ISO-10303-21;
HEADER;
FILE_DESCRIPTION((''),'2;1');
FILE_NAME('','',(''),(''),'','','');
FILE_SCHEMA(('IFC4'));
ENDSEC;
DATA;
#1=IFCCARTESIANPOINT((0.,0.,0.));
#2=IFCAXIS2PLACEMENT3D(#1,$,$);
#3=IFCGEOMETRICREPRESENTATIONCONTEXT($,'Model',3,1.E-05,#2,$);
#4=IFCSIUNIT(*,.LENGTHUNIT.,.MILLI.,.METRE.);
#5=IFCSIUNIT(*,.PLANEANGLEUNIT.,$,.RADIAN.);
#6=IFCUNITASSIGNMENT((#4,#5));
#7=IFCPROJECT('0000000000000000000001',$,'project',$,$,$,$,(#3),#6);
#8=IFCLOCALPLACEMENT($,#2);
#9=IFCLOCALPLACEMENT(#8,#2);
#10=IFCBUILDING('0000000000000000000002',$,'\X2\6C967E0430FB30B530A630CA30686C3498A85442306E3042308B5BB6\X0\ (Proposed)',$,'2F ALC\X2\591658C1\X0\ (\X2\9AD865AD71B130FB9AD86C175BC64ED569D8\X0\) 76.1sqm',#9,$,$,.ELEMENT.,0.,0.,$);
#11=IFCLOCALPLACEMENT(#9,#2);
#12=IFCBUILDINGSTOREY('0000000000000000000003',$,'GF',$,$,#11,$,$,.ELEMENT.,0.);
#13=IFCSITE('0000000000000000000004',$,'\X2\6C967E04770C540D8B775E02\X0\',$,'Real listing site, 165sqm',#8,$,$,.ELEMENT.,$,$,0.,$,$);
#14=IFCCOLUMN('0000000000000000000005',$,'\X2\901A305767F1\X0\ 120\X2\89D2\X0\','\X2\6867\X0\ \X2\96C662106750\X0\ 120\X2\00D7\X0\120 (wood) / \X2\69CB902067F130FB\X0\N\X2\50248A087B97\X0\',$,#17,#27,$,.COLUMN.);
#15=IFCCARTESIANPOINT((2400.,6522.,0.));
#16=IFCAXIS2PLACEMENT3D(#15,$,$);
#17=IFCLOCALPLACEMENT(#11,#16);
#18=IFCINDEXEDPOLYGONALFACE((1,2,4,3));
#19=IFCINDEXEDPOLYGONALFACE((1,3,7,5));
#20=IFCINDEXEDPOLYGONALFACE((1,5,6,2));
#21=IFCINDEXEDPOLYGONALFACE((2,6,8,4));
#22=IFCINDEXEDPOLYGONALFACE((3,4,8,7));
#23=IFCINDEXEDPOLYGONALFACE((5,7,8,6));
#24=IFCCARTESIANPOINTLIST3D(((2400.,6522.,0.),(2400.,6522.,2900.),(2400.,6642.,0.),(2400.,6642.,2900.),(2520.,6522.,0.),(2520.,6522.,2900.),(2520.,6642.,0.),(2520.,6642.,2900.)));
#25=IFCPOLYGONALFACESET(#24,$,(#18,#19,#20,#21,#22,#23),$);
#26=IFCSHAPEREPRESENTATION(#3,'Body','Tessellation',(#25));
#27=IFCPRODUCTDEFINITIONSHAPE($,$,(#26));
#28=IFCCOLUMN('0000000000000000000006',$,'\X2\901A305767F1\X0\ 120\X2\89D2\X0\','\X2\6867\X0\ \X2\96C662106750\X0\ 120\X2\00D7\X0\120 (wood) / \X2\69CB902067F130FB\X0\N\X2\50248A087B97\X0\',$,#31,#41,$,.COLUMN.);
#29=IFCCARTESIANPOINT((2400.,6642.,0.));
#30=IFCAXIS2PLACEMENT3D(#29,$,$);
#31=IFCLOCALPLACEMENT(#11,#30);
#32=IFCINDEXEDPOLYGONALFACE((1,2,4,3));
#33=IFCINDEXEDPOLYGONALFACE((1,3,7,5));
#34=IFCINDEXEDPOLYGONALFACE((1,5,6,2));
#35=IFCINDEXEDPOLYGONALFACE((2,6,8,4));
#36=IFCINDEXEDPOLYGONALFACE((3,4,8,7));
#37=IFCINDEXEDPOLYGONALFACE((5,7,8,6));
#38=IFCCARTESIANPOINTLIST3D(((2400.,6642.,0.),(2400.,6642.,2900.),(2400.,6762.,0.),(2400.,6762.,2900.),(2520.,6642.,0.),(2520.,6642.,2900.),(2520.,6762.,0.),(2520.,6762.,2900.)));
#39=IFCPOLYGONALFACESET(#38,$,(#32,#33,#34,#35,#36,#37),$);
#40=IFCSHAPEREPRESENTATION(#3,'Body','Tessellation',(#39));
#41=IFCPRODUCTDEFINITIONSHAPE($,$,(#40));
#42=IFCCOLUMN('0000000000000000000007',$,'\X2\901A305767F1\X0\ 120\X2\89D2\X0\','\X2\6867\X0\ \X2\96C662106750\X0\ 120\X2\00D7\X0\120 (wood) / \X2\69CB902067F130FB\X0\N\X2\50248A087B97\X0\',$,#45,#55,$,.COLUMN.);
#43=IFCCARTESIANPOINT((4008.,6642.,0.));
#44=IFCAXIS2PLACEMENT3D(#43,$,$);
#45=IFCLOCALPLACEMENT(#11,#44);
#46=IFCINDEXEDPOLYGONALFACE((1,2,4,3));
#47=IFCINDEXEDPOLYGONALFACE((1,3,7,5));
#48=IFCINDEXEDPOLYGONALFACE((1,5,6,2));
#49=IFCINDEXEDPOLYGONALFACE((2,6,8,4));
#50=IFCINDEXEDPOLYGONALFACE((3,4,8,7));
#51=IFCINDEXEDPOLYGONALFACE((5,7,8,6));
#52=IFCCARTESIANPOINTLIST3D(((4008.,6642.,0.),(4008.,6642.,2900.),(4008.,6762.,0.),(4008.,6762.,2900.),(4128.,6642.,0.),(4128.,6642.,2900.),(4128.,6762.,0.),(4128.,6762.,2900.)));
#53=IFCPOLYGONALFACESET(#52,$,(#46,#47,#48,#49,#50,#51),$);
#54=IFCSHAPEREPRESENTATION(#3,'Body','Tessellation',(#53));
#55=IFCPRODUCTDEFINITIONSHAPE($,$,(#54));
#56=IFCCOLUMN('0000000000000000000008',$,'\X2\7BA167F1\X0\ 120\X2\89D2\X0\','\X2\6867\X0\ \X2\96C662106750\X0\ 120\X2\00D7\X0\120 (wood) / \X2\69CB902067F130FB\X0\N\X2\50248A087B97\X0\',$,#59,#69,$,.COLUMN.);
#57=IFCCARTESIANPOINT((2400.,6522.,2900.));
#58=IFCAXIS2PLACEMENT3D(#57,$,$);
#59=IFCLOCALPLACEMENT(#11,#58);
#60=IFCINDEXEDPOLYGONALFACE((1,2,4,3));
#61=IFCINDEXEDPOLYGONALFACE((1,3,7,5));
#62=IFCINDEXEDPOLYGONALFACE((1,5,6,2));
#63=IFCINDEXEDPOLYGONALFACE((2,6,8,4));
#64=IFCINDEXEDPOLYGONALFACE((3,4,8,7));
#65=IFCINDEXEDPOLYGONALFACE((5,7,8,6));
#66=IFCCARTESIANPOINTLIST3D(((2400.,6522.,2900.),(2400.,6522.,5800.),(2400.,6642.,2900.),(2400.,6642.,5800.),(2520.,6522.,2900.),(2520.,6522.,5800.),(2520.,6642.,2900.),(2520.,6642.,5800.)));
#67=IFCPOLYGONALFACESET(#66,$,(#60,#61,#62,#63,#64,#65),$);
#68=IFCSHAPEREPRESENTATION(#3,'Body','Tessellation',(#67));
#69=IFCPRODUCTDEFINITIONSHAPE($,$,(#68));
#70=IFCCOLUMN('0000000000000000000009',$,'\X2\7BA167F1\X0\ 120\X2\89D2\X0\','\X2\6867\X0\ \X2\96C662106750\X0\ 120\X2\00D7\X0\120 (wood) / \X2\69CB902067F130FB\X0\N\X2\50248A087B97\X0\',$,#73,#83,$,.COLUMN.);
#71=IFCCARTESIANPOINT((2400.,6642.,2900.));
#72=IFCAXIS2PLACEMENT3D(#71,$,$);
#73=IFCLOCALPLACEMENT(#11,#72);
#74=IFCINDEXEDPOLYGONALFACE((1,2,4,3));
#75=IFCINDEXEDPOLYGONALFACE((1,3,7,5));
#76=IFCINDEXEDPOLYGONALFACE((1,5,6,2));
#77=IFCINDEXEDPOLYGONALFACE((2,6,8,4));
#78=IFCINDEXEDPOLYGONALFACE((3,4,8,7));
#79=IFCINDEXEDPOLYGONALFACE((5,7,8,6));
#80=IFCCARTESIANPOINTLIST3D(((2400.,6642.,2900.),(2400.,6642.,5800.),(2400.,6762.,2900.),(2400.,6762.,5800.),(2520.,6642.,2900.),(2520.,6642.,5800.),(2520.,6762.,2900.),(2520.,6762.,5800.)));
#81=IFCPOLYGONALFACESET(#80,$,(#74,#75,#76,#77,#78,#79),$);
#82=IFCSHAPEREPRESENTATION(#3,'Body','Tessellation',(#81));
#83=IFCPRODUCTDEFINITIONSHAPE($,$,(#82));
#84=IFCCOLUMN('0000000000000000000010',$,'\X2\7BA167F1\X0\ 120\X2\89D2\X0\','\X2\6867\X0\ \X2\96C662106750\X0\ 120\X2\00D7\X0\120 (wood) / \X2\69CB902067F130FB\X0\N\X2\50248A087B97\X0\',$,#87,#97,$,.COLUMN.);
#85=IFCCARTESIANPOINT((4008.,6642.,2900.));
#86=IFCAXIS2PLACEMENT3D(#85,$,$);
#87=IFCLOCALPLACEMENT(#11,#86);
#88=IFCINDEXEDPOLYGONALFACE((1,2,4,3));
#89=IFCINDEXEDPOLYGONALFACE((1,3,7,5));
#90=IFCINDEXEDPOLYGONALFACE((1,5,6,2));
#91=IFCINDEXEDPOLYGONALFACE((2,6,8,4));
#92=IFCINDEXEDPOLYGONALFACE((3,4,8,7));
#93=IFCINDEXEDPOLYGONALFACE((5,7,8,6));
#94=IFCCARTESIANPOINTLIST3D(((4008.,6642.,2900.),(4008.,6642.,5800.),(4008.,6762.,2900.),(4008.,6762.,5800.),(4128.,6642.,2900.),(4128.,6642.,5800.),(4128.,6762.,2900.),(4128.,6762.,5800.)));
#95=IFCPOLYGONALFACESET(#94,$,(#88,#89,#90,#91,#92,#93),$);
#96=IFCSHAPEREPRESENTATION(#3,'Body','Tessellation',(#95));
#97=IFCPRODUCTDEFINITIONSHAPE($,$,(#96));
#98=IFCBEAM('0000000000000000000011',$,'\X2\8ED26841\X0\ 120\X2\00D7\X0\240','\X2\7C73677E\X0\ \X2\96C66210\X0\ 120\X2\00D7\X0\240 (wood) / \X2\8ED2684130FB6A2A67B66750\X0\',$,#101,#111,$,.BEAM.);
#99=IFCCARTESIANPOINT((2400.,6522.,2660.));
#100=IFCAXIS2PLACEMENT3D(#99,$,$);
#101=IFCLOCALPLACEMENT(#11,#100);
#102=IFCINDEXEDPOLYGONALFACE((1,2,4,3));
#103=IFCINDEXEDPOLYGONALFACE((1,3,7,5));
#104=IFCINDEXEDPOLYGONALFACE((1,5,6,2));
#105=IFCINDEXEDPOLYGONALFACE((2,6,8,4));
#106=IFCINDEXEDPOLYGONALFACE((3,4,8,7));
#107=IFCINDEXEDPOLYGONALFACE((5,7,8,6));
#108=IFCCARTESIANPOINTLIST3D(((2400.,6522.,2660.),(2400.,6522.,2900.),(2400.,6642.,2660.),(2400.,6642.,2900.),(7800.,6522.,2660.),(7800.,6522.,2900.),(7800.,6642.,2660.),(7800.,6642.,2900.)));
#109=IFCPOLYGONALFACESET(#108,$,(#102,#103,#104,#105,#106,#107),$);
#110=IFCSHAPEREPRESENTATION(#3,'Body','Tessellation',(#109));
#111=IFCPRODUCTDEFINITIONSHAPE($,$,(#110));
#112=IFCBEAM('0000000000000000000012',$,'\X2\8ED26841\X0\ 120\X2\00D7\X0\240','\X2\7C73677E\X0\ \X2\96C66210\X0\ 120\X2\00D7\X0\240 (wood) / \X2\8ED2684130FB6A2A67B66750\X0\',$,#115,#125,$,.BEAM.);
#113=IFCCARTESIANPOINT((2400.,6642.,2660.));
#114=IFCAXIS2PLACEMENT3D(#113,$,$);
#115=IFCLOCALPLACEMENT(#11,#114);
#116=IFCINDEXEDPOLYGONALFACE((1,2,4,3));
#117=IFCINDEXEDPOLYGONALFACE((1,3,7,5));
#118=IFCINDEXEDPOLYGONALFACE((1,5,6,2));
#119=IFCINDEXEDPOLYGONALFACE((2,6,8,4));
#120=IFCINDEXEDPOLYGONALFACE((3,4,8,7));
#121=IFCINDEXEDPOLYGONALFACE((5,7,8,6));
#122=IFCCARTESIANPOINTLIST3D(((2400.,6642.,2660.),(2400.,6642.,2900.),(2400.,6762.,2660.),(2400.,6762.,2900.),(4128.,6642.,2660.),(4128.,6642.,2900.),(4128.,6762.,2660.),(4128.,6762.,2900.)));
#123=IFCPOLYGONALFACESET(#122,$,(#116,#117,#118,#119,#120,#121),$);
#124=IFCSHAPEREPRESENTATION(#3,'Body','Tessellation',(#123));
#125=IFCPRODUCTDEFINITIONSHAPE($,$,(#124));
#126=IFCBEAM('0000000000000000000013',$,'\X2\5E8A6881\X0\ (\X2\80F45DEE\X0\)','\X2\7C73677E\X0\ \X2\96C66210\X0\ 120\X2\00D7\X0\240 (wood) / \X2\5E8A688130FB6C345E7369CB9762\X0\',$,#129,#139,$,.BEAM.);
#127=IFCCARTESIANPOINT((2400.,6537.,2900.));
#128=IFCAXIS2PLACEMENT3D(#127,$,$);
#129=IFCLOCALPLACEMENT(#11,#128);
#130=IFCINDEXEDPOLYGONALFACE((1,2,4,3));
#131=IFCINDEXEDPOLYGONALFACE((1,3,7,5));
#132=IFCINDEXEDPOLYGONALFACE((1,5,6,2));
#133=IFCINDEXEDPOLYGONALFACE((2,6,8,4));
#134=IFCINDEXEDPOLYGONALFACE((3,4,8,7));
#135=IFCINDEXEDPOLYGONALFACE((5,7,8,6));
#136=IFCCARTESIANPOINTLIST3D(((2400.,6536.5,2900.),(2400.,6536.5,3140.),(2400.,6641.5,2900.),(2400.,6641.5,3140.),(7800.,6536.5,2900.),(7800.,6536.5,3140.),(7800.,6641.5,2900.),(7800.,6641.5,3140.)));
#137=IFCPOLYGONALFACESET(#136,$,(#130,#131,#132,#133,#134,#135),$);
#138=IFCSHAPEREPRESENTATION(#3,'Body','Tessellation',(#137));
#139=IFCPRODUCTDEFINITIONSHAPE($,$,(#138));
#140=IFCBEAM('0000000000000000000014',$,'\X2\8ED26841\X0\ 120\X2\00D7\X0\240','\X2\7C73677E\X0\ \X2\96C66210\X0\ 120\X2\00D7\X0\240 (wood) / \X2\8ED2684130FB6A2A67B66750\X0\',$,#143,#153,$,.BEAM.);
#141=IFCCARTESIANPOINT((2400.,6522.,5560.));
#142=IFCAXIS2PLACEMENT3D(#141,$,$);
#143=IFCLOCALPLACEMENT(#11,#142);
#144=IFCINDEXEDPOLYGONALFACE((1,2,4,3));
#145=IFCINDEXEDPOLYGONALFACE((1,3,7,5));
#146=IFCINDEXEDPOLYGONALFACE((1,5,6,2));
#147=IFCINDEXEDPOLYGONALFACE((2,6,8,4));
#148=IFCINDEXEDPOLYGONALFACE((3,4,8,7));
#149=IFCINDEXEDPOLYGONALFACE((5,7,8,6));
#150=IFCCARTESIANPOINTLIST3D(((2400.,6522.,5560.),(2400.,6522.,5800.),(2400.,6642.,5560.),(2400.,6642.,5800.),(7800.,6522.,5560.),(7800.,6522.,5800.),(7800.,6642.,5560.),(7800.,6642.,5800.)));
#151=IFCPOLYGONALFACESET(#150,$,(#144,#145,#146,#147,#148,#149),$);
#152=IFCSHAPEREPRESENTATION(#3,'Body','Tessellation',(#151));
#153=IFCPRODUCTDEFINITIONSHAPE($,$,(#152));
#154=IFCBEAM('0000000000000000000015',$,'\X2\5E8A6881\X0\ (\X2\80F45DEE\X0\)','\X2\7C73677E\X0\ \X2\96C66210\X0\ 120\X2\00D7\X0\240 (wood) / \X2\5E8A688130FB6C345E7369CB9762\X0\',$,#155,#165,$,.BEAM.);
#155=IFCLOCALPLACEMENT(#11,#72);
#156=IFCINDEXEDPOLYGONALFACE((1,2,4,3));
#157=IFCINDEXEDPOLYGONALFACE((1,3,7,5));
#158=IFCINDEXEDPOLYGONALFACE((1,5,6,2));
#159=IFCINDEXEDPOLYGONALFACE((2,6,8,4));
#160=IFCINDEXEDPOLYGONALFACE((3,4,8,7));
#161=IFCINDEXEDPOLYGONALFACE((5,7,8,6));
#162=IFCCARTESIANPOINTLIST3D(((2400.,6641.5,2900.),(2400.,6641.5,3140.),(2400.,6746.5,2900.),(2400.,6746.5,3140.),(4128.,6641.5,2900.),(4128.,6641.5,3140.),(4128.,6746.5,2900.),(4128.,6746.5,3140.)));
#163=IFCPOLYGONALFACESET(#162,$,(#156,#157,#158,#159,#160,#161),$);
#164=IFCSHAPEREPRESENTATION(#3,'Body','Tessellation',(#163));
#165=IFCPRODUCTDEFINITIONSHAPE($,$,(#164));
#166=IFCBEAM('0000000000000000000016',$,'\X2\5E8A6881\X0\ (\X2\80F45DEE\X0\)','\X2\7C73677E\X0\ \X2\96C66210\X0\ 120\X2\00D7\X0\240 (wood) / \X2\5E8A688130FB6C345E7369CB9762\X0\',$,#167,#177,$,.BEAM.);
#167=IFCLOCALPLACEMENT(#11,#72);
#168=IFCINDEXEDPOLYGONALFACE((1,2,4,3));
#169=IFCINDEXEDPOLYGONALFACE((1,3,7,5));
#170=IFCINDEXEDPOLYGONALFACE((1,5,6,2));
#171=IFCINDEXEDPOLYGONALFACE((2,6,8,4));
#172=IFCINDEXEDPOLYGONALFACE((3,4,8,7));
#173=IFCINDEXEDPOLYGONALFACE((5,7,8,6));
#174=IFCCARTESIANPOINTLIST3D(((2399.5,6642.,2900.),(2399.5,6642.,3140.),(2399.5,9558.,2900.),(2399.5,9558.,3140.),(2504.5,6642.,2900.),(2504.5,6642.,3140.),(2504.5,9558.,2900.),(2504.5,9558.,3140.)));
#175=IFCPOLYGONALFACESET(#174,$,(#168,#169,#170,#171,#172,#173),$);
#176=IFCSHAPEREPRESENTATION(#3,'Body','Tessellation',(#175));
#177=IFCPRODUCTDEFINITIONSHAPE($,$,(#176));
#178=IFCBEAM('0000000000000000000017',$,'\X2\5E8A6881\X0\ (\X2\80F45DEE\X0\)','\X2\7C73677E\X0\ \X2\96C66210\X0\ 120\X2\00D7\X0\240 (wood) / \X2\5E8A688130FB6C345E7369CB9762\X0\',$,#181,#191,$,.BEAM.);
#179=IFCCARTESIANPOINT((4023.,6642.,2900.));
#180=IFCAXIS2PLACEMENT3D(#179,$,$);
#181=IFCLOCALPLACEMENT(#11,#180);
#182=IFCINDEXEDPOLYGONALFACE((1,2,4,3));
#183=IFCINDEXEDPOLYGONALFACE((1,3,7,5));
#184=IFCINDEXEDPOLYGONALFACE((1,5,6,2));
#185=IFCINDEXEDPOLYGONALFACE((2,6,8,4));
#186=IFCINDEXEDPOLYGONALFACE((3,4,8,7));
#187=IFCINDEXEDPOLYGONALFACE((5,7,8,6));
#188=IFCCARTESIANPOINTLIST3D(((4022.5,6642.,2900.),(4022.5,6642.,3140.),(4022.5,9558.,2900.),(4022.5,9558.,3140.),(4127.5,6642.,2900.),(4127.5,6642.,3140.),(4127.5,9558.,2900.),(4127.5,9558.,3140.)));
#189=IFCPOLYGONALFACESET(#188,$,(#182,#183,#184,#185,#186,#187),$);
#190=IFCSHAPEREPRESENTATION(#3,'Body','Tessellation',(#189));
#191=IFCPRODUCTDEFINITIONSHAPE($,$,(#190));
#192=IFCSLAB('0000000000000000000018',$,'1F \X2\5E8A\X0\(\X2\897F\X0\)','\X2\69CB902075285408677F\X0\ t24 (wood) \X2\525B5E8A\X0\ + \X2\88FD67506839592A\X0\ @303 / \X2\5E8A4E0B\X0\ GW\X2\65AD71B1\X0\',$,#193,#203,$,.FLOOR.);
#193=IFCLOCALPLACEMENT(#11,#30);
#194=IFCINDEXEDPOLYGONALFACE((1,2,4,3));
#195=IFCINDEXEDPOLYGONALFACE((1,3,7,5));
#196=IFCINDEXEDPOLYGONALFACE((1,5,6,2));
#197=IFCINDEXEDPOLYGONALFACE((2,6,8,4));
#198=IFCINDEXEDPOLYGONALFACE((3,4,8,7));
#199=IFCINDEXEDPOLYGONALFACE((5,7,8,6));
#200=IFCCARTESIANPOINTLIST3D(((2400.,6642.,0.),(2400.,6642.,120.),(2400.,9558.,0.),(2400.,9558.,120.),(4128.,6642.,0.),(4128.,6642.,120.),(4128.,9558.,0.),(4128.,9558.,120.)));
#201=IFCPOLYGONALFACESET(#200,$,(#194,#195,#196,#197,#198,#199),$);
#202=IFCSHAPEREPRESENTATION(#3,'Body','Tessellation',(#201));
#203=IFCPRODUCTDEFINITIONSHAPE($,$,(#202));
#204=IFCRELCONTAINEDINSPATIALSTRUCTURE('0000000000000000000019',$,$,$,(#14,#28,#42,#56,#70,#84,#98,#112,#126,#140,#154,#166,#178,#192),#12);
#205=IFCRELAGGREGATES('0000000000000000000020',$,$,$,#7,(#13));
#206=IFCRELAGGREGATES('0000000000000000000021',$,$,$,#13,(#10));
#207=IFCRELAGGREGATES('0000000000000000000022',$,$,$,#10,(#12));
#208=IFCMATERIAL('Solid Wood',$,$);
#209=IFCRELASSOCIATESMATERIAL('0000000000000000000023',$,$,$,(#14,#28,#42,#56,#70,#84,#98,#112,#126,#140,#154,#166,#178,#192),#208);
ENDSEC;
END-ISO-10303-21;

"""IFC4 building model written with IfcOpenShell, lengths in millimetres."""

from ifc_helpers import new_model, si_unit, frame, frame_2d, origin, place, context, project, spatial, rectangle, extrude, material, element, save


model = new_model("IFC4")

# Units and contexts
model_context = context("Model", 3, precision=1e-05, world=origin())
ifc_project = project(units=[si_unit("LENGTHUNIT", "METRE", prefix="MILLI"), si_unit("PLANEANGLEUNIT", "RADIAN")], contexts=[model_context])

# Site, building, storey
site_placement = place(None, origin())
site = spatial("IfcSite", under=ifc_project, at=site_placement, Name="沖縄県名護市", ObjectType="Real listing site, 165sqm", CompositionType="ELEMENT", RefElevation=0.0)
building_placement = place(site_placement, origin())
building = spatial("IfcBuilding", under=site, at=building_placement, Name="沖縄・サウナと水風呂のある家 (Proposed)", ObjectType="2F ALC外壁 (高断熱・高気密仕様) 76.1sqm", CompositionType="ELEMENT", ElevationOfRefHeight=0.0, ElevationOfTerrain=0.0)
storey_placement = place(building_placement, origin())
storey = spatial("IfcBuildingStorey", under=building, at=storey_placement, Name="GF", CompositionType="ELEMENT", Elevation=0.0)

# Columns
ifc_material_1 = material(Name="Solid Wood")
column_1_placement = place(storey_placement, frame((2400.0, 6522.0, 0.0)))
element("IfcColumn", 1, at=column_1_placement, inside=storey, material=ifc_material_1, Name="通し柱 120角", Description="桧 集成材 120×120 (wood) / 構造柱・N値計算", PredefinedType="COLUMN", context=model_context, shape_type="SweptSolid", body=[
    extrude(rectangle(XDim=120.0, YDim=120.0, at=frame_2d((60.0, 60.0))), frame((2400.0, 6522.0, 0.0)), (0.0, 0.0, 1.0), 2900.0),
])
column_2_placement = place(storey_placement, frame((2400.0, 6642.0, 0.0)))
element("IfcColumn", 2, at=column_2_placement, inside=storey, material=ifc_material_1, Name="通し柱 120角", Description="桧 集成材 120×120 (wood) / 構造柱・N値計算", PredefinedType="COLUMN", context=model_context, shape_type="SweptSolid", body=[
    extrude(rectangle(XDim=120.0, YDim=120.0, at=frame_2d((60.0, 60.0))), frame((2400.0, 6642.0, 0.0)), (0.0, 0.0, 1.0), 2900.0),
])
column_3_placement = place(storey_placement, frame((4008.0, 6642.0, 0.0)))
element("IfcColumn", 3, at=column_3_placement, inside=storey, material=ifc_material_1, Name="通し柱 120角", Description="桧 集成材 120×120 (wood) / 構造柱・N値計算", PredefinedType="COLUMN", context=model_context, shape_type="SweptSolid", body=[
    extrude(rectangle(XDim=120.0, YDim=120.0, at=frame_2d((60.0, 60.0))), frame((4008.0, 6642.0, 0.0)), (0.0, 0.0, 1.0), 2900.0),
])
column_4_placement = place(storey_placement, frame((2400.0, 6522.0, 2900.0)))
element("IfcColumn", 4, at=column_4_placement, inside=storey, material=ifc_material_1, Name="管柱 120角", Description="桧 集成材 120×120 (wood) / 構造柱・N値計算", PredefinedType="COLUMN", context=model_context, shape_type="SweptSolid", body=[
    extrude(rectangle(XDim=120.0, YDim=120.0, at=frame_2d((60.0, 60.0))), frame((2400.0, 6522.0, 2900.0)), (0.0, 0.0, 1.0), 2900.0),
])
column_5_placement = place(storey_placement, frame((2400.0, 6642.0, 2900.0)))
element("IfcColumn", 5, at=column_5_placement, inside=storey, material=ifc_material_1, Name="管柱 120角", Description="桧 集成材 120×120 (wood) / 構造柱・N値計算", PredefinedType="COLUMN", context=model_context, shape_type="SweptSolid", body=[
    extrude(rectangle(XDim=120.0, YDim=120.0, at=frame_2d((60.0, 60.0))), frame((2400.0, 6642.0, 2900.0)), (0.0, 0.0, 1.0), 2900.0),
])
column_6_placement = place(storey_placement, frame((4008.0, 6642.0, 2900.0)))
element("IfcColumn", 6, at=column_6_placement, inside=storey, material=ifc_material_1, Name="管柱 120角", Description="桧 集成材 120×120 (wood) / 構造柱・N値計算", PredefinedType="COLUMN", context=model_context, shape_type="SweptSolid", body=[
    extrude(rectangle(XDim=120.0, YDim=120.0, at=frame_2d((60.0, 60.0))), frame((4008.0, 6642.0, 2900.0)), (0.0, 0.0, 1.0), 2900.0),
])

# Beams
beam_1_placement = place(storey_placement, frame((2400.0, 6522.0, 2660.0)))
element("IfcBeam", 7, at=beam_1_placement, inside=storey, material=ifc_material_1, Name="軒桁 120×240", Description="米松 集成 120×240 (wood) / 軒桁・横架材", PredefinedType="BEAM", context=model_context, shape_type="SweptSolid", body=[
    extrude(rectangle(XDim=5400.0, YDim=120.0, at=frame_2d((2700.0, 60.0))), frame((2400.0, 6522.0, 2660.0)), (0.0, 0.0, 1.0), 240.0),
])
beam_2_placement = place(storey_placement, frame((2400.0, 6642.0, 2660.0)))
element("IfcBeam", 8, at=beam_2_placement, inside=storey, material=ifc_material_1, Name="軒桁 120×240", Description="米松 集成 120×240 (wood) / 軒桁・横架材", PredefinedType="BEAM", context=model_context, shape_type="SweptSolid", body=[
    extrude(rectangle(XDim=1728.0, YDim=120.0, at=frame_2d((864.0, 60.0))), frame((2400.0, 6642.0, 2660.0)), (0.0, 0.0, 1.0), 240.0),
])
beam_3_placement = place(storey_placement, frame((2400.0, 6537.0, 2900.0)))
element("IfcBeam", 9, at=beam_3_placement, inside=storey, material=ifc_material_1, Name="床梁 (胴差)", Description="米松 集成 120×240 (wood) / 床梁・水平構面", PredefinedType="BEAM", context=model_context, shape_type="SweptSolid", body=[
    extrude(rectangle(XDim=5400.0, YDim=105.0, at=frame_2d((2700.0, 52.0))), frame((2400.0, 6537.0, 2900.0)), (0.0, 0.0, 1.0), 240.0),
])
beam_4_placement = place(storey_placement, frame((2400.0, 6522.0, 5560.0)))
element("IfcBeam", 10, at=beam_4_placement, inside=storey, material=ifc_material_1, Name="軒桁 120×240", Description="米松 集成 120×240 (wood) / 軒桁・横架材", PredefinedType="BEAM", context=model_context, shape_type="SweptSolid", body=[
    extrude(rectangle(XDim=5400.0, YDim=120.0, at=frame_2d((2700.0, 60.0))), frame((2400.0, 6522.0, 5560.0)), (0.0, 0.0, 1.0), 240.0),
])
beam_5_placement = place(storey_placement, frame((2400.0, 6642.0, 2900.0)))
element("IfcBeam", 11, at=beam_5_placement, inside=storey, material=ifc_material_1, Name="床梁 (胴差)", Description="米松 集成 120×240 (wood) / 床梁・水平構面", PredefinedType="BEAM", context=model_context, shape_type="SweptSolid", body=[
    extrude(rectangle(XDim=1728.0, YDim=105.0, at=frame_2d((864.0, 52.0))), frame((2400.0, 6642.0, 2900.0)), (0.0, 0.0, 1.0), 240.0),
])
beam_6_placement = place(storey_placement, frame((2400.0, 6642.0, 2900.0)))
element("IfcBeam", 12, at=beam_6_placement, inside=storey, material=ifc_material_1, Name="床梁 (胴差)", Description="米松 集成 120×240 (wood) / 床梁・水平構面", PredefinedType="BEAM", context=model_context, shape_type="SweptSolid", body=[
    extrude(rectangle(XDim=105.0, YDim=2916.0, at=frame_2d((52.0, 1458.0))), frame((2400.0, 6642.0, 2900.0)), (0.0, 0.0, 1.0), 240.0),
])
beam_7_placement = place(storey_placement, frame((4023.0, 6642.0, 2900.0)))
element("IfcBeam", 13, at=beam_7_placement, inside=storey, material=ifc_material_1, Name="床梁 (胴差)", Description="米松 集成 120×240 (wood) / 床梁・水平構面", PredefinedType="BEAM", context=model_context, shape_type="SweptSolid", body=[
    extrude(rectangle(XDim=105.0, YDim=2916.0, at=frame_2d((52.0, 1458.0))), frame((4023.0, 6642.0, 2900.0)), (0.0, 0.0, 1.0), 240.0),
])

# Slab
slab_1_placement = place(storey_placement, frame((2400.0, 6642.0, 0.0)))
element("IfcSlab", 14, at=slab_1_placement, inside=storey, material=ifc_material_1, Name="1F 床(西)", Description="構造用合板 t24 (wood) 剛床 + 製材根太 @303 / 床下 GW断熱", PredefinedType="FLOOR", context=model_context, shape_type="SweptSolid", body=[
    extrude(rectangle(XDim=1728.0, YDim=2916.0, at=frame_2d((864.0, 1458.0))), frame((2400.0, 6642.0, 0.0)), (0.0, 0.0, 1.0), 120.0),
])

save(model, "model.ifc")
